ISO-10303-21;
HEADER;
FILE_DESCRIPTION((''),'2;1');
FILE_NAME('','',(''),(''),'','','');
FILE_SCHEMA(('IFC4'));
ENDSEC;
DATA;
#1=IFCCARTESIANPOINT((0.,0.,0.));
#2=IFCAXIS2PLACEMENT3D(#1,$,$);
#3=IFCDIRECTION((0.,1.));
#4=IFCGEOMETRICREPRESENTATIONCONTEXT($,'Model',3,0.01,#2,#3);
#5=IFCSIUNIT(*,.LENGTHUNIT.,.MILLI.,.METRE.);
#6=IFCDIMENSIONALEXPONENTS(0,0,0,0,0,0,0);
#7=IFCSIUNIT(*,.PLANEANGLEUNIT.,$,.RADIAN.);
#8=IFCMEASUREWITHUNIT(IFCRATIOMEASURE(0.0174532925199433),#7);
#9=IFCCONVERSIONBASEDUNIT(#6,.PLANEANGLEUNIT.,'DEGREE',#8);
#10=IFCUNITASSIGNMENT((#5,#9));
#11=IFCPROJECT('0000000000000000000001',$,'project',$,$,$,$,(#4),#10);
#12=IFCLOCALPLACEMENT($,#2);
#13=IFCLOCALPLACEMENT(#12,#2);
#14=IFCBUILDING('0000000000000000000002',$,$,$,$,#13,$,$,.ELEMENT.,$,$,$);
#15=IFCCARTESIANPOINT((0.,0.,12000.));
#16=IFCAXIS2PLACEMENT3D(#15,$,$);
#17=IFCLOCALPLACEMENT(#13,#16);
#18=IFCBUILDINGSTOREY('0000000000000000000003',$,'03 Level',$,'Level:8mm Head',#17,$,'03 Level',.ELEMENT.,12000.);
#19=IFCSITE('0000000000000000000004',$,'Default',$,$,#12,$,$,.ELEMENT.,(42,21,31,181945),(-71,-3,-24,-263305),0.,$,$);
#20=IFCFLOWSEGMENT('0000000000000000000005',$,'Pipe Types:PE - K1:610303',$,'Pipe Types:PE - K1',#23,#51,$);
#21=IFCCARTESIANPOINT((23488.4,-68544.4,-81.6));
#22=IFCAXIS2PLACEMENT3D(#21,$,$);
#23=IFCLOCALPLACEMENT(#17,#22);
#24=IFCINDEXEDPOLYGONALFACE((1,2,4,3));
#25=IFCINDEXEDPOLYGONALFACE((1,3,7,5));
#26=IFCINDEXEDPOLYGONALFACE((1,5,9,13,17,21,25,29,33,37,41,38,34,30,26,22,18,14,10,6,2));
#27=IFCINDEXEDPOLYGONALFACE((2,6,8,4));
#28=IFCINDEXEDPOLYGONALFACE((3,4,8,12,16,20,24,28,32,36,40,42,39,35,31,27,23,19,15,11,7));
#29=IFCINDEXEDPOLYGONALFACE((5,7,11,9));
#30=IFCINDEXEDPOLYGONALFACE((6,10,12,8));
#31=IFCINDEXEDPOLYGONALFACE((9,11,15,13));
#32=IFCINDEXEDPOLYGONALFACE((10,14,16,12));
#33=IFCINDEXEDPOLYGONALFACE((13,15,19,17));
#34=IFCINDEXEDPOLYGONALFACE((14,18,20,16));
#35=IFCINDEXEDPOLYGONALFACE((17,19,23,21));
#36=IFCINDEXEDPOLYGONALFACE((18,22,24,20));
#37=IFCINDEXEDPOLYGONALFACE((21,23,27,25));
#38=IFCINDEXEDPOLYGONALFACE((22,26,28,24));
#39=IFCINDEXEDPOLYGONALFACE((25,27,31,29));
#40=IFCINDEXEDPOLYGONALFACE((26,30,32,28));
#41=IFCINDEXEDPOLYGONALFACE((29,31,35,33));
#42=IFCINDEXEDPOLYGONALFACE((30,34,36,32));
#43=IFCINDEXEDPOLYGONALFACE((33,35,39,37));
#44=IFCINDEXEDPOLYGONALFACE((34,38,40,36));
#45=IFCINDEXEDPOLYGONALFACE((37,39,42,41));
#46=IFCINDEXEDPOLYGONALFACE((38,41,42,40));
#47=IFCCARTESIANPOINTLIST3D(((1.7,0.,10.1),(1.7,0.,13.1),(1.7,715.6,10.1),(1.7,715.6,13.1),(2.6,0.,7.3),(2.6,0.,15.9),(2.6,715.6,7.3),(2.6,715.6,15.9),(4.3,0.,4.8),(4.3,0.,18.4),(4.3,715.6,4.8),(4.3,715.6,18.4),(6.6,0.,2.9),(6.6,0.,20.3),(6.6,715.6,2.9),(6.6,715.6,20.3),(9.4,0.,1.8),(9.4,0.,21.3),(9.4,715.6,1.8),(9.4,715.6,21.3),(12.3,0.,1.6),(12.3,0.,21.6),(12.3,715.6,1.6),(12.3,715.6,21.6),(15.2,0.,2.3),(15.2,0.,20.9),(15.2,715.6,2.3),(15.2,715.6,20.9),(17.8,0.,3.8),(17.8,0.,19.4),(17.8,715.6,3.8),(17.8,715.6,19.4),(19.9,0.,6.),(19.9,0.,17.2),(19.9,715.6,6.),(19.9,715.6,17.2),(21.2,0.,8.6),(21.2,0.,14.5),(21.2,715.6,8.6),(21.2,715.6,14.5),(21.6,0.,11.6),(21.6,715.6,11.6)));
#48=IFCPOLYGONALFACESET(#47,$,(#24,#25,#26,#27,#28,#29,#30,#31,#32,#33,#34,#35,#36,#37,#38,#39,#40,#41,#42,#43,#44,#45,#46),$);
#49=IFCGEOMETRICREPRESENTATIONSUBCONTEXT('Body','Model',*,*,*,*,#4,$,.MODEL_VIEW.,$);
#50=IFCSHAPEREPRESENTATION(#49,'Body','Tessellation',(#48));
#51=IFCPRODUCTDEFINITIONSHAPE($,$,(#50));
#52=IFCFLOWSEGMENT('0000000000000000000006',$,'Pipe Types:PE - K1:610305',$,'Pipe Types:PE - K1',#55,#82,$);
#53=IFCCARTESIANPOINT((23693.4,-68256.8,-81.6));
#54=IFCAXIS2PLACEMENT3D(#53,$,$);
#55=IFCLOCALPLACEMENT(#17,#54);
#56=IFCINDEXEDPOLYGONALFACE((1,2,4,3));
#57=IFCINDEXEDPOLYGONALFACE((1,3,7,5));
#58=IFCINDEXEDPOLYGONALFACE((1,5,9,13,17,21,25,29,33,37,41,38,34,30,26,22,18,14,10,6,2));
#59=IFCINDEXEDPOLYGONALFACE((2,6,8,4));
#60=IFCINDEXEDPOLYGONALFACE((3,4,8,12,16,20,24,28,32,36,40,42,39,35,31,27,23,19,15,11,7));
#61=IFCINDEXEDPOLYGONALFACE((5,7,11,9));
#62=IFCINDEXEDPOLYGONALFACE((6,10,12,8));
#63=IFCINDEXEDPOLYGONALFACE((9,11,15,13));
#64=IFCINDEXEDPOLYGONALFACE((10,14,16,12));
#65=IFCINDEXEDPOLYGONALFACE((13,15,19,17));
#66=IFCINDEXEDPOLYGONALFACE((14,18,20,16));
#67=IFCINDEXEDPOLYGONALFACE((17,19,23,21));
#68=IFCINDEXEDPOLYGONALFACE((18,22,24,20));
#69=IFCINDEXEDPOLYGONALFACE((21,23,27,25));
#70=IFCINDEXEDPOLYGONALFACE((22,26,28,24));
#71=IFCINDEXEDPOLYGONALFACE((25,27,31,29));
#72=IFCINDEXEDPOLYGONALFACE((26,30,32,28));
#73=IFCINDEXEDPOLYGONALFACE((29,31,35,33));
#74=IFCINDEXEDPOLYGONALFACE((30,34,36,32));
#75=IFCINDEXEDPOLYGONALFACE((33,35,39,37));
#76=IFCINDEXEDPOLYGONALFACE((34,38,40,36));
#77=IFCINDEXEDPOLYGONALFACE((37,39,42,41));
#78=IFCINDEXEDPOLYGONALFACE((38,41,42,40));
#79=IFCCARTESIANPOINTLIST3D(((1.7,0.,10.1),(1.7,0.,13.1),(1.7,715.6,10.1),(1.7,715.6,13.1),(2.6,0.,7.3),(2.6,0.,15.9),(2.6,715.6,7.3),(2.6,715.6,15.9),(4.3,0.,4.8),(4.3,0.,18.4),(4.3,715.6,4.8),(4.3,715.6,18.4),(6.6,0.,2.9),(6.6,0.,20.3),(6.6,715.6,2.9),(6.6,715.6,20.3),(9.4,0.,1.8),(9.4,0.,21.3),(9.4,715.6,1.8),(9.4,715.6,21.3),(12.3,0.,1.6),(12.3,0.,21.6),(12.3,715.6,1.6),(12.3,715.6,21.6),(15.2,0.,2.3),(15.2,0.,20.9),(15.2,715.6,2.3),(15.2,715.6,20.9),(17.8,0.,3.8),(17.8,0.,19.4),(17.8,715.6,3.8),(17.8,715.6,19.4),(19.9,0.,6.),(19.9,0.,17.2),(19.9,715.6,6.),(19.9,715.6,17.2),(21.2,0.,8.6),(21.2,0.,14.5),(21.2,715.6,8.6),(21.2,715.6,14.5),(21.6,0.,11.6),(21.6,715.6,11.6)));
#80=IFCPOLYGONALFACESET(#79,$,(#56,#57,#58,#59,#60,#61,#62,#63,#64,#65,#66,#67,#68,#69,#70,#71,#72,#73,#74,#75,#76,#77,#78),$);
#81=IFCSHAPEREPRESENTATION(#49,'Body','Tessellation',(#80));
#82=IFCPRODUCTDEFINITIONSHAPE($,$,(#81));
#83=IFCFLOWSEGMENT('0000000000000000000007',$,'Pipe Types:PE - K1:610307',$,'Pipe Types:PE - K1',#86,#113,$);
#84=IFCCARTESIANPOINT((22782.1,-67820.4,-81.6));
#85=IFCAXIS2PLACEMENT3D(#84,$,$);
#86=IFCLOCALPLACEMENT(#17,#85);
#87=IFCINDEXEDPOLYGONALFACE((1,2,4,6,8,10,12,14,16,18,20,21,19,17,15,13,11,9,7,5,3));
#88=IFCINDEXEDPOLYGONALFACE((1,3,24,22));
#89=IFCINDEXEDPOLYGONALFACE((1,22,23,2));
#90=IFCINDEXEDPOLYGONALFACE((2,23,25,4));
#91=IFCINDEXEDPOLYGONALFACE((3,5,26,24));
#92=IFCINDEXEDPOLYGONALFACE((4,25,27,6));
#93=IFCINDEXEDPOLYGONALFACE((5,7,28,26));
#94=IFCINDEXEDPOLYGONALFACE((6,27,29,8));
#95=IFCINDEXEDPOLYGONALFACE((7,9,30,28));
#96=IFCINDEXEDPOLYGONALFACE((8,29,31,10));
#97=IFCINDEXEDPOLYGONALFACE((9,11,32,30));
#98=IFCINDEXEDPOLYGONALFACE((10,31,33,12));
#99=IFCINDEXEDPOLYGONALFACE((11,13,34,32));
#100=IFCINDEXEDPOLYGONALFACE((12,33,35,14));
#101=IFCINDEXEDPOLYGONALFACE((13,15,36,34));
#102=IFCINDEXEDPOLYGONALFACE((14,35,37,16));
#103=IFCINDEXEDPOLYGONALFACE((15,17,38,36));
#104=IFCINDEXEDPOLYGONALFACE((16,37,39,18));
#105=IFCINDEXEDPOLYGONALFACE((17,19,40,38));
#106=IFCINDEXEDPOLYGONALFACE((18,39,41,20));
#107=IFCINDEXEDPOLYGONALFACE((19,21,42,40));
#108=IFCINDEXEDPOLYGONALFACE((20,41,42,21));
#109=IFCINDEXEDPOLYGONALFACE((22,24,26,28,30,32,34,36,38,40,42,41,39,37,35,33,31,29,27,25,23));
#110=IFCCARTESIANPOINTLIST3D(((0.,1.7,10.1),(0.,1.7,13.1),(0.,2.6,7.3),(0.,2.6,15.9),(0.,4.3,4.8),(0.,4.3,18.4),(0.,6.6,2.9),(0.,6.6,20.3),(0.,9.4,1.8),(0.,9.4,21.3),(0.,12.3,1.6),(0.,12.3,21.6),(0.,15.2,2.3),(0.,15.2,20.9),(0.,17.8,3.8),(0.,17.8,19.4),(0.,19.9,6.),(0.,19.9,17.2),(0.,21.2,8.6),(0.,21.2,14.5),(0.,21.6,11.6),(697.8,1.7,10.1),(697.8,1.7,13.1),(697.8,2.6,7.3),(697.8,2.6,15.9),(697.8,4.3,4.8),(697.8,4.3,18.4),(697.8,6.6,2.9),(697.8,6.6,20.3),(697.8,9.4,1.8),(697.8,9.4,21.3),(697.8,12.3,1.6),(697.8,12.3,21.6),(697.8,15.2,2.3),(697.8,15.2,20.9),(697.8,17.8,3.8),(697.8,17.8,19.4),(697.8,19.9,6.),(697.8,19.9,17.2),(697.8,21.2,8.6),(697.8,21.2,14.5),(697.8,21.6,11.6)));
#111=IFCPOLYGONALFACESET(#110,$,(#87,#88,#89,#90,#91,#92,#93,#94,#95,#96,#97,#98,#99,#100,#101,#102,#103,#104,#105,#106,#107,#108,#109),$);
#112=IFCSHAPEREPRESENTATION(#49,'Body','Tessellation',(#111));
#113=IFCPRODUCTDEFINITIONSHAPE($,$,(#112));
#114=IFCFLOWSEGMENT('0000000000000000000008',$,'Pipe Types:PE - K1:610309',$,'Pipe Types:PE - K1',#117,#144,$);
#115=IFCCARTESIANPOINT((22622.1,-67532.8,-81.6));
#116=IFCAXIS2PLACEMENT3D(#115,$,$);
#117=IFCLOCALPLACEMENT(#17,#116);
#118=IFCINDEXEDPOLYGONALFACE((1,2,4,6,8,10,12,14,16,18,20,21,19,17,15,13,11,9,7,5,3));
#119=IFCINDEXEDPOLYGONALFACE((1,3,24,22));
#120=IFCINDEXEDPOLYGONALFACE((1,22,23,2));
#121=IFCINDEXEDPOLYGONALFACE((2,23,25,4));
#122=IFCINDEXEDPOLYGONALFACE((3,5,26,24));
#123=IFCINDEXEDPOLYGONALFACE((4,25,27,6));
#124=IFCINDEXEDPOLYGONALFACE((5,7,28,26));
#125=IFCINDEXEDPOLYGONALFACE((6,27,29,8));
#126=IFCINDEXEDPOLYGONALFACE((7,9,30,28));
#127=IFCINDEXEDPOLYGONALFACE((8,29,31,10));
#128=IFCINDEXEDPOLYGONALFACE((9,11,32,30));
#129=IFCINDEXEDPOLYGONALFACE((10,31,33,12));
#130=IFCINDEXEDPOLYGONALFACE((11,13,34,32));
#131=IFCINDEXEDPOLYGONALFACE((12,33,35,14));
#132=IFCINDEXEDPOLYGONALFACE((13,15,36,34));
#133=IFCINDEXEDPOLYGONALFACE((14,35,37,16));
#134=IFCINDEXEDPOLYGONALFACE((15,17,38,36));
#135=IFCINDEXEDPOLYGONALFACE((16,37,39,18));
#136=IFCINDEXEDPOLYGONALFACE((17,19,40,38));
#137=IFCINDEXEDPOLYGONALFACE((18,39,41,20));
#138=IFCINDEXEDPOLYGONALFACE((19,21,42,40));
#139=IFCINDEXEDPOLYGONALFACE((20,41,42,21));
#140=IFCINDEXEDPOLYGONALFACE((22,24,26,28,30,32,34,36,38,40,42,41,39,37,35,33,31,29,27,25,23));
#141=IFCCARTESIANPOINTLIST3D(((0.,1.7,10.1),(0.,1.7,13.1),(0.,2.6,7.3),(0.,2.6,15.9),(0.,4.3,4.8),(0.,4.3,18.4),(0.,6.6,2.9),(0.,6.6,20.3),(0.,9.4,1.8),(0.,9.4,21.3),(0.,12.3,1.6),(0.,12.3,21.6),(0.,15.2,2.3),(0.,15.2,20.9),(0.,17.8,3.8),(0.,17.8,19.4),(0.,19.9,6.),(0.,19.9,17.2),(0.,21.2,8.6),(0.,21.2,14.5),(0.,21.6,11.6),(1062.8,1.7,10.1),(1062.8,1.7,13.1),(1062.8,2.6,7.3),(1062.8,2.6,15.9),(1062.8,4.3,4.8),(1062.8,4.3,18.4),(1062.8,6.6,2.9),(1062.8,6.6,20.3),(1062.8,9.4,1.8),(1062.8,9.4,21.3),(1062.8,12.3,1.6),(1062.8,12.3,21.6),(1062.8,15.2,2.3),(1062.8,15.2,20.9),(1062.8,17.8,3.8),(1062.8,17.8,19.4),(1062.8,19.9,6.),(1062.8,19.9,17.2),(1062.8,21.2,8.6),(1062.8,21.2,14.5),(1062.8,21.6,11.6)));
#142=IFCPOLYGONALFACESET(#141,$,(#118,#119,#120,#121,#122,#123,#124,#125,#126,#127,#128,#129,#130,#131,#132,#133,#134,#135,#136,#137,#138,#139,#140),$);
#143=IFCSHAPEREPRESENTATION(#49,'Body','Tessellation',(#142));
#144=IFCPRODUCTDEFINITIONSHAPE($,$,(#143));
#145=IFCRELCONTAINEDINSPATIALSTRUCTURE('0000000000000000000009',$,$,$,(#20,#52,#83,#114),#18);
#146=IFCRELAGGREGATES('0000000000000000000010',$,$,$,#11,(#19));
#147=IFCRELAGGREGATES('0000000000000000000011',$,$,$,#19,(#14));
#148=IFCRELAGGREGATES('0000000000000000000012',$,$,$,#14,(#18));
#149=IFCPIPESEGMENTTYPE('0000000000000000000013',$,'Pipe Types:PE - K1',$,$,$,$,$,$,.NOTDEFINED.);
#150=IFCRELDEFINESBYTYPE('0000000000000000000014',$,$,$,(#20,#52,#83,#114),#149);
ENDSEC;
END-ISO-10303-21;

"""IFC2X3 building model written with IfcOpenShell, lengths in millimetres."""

from ifc_helpers import new_model, entity, si_unit, converted_unit, direction, frame, frame_2d, origin, origin_2d_with_axis, place, context, subcontext, project, spatial, circle, extrude, type_object, element, save


model = new_model("IFC2X3")

# Units and contexts
model_context = context("Model", 3, precision=0.01, world=origin(), true_north=direction((0.0, 1.0)))
body_context = subcontext(model_context, "Body", "Model", "MODEL_VIEW")
ifc_project = project(units=[si_unit("LENGTHUNIT", "METRE", prefix="MILLI"), converted_unit("PLANEANGLEUNIT", "DEGREE", entity("IfcRatioMeasure", 0.0174532925199433), si_unit("PLANEANGLEUNIT", "RADIAN"), dimensions=[0, 0, 0, 0, 0, 0, 0])], contexts=[model_context])

# Site, building, storey
site_placement = place(None, origin())
site = spatial("IfcSite", under=ifc_project, at=site_placement, Name="Default", CompositionType="ELEMENT", RefLatitude=(42, 21, 31, 181945), RefLongitude=(-71, -3, -24, -263305), RefElevation=0.0)
building_placement = place(site_placement, origin())
building = spatial("IfcBuilding", under=site, at=building_placement, CompositionType="ELEMENT")
storey_placement = place(building_placement, frame((0.0, 0.0, 12000.0)))
storey = spatial("IfcBuildingStorey", under=building, at=storey_placement, Name="03 Level", ObjectType="Level:8mm Head", LongName="03 Level", CompositionType="ELEMENT", Elevation=12000.0)

# Flow segments
pipe_segment_type = type_object("IfcPipeSegmentType", Name="Pipe Types:PE - K1", PredefinedType="NOTDEFINED")
flow_segment_1_placement = place(storey_placement, frame((23488.4, -68544.4, -81.6)))
element("IfcFlowSegment", 1, at=flow_segment_1_placement, inside=storey, type_object=pipe_segment_type, Name="Pipe Types:PE - K1:610303", ObjectType="Pipe Types:PE - K1", context=body_context, shape_type="SweptSolid", body=[
    extrude(circle(Radius=10.0, at=origin_2d_with_axis()), frame((11.6, 0.0, 11.6), z_axis=(0.0, 1.0, 0.0), x_axis=(1.0, 0.0, 0.0)), (0.0, 0.0, 1.0), 715.6),
])
flow_segment_2_placement = place(storey_placement, frame((23693.4, -68256.8, -81.6)))
element("IfcFlowSegment", 2, at=flow_segment_2_placement, inside=storey, type_object=pipe_segment_type, Name="Pipe Types:PE - K1:610305", ObjectType="Pipe Types:PE - K1", context=body_context, shape_type="SweptSolid", body=[
    extrude(circle(Radius=10.0, at=origin_2d_with_axis()), frame((11.6, 0.0, 11.6), z_axis=(0.0, 1.0, 0.0), x_axis=(1.0, 0.0, 0.0)), (0.0, 0.0, 1.0), 715.6),
])
flow_segment_3_placement = place(storey_placement, frame((22782.1, -67820.4, -81.6)))
element("IfcFlowSegment", 3, at=flow_segment_3_placement, inside=storey, type_object=pipe_segment_type, Name="Pipe Types:PE - K1:610307", ObjectType="Pipe Types:PE - K1", context=body_context, shape_type="SweptSolid", body=[
    extrude(circle(Radius=10.0, at=frame_2d((0.0, 0.0), x_axis=(1.0, 0.0))), frame((0.0, 11.6, 11.6), z_axis=(1.0, 0.0, 0.0), x_axis=(0.0, 1.0, 0.0)), (0.0, 0.0, 1.0), 697.8),
])
flow_segment_4_placement = place(storey_placement, frame((22622.1, -67532.8, -81.6)))
element("IfcFlowSegment", 4, at=flow_segment_4_placement, inside=storey, type_object=pipe_segment_type, Name="Pipe Types:PE - K1:610309", ObjectType="Pipe Types:PE - K1", context=body_context, shape_type="SweptSolid", body=[
    extrude(circle(Radius=10.0, at=frame_2d((0.0, 0.0), x_axis=(1.0, 0.0))), frame((0.0, 11.6, 11.6), z_axis=(1.0, 0.0, 0.0), x_axis=(0.0, 1.0, 0.0)), (0.0, 0.0, 1.0), 1062.8),
])

save(model, "model.ifc")
